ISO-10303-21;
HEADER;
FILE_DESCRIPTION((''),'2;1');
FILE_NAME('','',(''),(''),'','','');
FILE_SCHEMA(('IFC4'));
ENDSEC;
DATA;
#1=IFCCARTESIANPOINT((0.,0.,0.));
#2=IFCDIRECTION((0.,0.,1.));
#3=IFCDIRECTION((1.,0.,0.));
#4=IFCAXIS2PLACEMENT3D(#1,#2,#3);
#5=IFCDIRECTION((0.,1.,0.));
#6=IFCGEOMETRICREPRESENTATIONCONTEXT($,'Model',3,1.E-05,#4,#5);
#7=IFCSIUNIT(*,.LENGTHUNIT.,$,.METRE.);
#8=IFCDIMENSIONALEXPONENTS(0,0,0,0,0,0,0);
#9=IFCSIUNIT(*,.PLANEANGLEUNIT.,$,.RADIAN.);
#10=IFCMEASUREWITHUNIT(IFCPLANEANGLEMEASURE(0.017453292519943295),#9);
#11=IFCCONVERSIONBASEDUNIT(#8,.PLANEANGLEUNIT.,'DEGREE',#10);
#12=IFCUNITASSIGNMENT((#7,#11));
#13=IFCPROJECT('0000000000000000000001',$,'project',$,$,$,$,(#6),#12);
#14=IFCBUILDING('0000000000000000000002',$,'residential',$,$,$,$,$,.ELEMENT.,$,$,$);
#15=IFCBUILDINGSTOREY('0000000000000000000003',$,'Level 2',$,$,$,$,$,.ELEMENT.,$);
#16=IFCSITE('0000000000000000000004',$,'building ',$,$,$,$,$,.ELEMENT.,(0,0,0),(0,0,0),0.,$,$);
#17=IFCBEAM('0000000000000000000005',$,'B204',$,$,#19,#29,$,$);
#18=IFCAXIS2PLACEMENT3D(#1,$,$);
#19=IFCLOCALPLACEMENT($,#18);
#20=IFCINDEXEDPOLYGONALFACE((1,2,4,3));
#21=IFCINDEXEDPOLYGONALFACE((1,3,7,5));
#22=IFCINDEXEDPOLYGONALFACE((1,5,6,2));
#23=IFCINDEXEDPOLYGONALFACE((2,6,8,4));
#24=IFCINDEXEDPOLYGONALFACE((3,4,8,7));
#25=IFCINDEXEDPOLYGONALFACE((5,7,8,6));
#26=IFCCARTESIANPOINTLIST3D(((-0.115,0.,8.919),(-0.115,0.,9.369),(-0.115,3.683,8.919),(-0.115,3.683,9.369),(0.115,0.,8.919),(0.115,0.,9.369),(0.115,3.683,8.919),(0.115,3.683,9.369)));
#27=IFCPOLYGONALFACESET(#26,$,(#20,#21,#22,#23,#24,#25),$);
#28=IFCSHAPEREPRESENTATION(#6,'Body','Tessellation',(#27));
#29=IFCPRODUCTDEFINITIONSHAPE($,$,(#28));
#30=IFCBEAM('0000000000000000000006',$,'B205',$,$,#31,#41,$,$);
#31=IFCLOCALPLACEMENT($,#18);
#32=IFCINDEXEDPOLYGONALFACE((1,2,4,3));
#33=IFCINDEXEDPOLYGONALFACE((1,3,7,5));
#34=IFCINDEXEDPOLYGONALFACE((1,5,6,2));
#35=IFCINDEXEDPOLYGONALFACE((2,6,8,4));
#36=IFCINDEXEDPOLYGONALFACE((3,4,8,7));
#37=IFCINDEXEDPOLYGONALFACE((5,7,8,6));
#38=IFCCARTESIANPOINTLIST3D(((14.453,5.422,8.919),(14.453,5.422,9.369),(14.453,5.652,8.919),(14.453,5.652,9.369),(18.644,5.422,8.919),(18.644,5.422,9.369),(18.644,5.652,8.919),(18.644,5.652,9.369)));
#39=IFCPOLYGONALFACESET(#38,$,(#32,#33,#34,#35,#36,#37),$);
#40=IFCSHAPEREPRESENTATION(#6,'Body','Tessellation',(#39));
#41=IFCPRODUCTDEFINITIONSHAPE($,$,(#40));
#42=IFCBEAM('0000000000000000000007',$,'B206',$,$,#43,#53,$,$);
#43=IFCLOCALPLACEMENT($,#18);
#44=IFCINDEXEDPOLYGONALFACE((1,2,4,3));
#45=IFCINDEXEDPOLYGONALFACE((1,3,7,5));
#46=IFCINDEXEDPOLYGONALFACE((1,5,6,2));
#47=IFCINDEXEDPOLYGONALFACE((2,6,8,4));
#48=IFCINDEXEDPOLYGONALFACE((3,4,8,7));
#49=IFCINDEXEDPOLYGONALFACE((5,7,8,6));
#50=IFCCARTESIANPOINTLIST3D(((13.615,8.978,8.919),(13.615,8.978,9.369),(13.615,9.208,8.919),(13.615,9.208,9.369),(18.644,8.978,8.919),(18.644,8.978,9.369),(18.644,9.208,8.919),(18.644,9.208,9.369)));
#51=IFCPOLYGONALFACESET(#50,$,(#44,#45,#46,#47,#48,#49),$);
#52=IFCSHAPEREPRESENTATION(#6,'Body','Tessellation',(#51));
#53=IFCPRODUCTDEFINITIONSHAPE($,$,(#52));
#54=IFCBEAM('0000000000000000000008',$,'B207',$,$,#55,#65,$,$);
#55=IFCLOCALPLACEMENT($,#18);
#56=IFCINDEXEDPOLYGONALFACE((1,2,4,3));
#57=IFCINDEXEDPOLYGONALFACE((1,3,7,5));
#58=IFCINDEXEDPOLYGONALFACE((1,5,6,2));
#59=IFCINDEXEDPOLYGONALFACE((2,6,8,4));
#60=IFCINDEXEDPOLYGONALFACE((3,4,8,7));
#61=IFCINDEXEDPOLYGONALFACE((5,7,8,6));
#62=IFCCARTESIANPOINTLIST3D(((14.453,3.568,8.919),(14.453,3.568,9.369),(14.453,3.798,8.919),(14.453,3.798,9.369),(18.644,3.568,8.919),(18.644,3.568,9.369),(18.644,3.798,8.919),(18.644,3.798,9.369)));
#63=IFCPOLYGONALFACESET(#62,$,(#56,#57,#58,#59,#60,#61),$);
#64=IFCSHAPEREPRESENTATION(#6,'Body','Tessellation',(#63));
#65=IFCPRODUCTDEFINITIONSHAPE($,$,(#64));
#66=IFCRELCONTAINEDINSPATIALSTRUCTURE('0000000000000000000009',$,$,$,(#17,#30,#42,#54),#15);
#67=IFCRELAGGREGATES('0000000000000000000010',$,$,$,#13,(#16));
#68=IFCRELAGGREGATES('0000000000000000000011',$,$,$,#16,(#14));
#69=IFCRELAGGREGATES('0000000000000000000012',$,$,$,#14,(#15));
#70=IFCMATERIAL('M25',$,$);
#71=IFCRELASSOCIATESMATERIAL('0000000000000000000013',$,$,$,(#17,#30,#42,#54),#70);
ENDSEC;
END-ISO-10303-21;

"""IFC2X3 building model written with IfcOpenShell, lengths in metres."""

from ifc_helpers import new_model, entity, si_unit, converted_unit, direction, frame, frame_2d, origin_with_axes, place, context, project, spatial, rectangle, extrude, material, element, save


model = new_model("IFC2X3")

# Units and contexts
model_context = context("Model", 3, precision=1e-05, world=origin_with_axes(), true_north=direction((0.0, 1.0, 0.0)))
ifc_project = project(units=[si_unit("LENGTHUNIT", "METRE"), converted_unit("PLANEANGLEUNIT", "DEGREE", entity("IfcPlaneAngleMeasure", 0.017453292519943295), si_unit("PLANEANGLEUNIT", "RADIAN"), dimensions=[0, 0, 0, 0, 0, 0, 0])], contexts=[model_context])

# Site, building, storey
site = spatial("IfcSite", under=ifc_project, Name="building ", CompositionType="ELEMENT", RefLatitude=(0, 0, 0), RefLongitude=(0, 0, 0), RefElevation=0.0)
building = spatial("IfcBuilding", under=site, Name="residential", CompositionType="ELEMENT")
storey = spatial("IfcBuildingStorey", under=building, Name="Level 2", CompositionType="ELEMENT")

# Shared definitions
ifc_material = material(Name="M25")
placement = place(None, origin_with_axes())

# Beams
element("IfcBeam", 1, at=placement, inside=storey, material=ifc_material, Name="B204", context=model_context, shape_type="SweptSolid", body=[
    extrude(rectangle(XDim=0.23, YDim=0.45, at=frame_2d((0.0, 0.0), x_axis=(0.0, 1.0, 0.0))), frame((0.0, 0.0, 9.144), z_axis=(0.0, 1.0, 0.0), x_axis=(0.0, 0.0, -1.0)), (0.0, 0.0, 1.0), 3.683),
])
element("IfcBeam", 2, at=placement, inside=storey, material=ifc_material, Name="B205", context=model_context, shape_type="SweptSolid", body=[
    extrude(rectangle(XDim=0.23, YDim=0.45, at=frame_2d((0.0, 0.0), x_axis=(0.0, 1.0, 0.0))), frame((18.644, 5.537, 9.144), z_axis=(-1.0, 0.0, 0.0), x_axis=(0.0, 0.0, -1.0)), (0.0, 0.0, 1.0), 4.191),
])
element("IfcBeam", 3, at=placement, inside=storey, material=ifc_material, Name="B206", context=model_context, shape_type="SweptSolid", body=[
    extrude(rectangle(XDim=0.23, YDim=0.45, at=frame_2d((0.0, 0.0), x_axis=(0.0, 1.0, 0.0))), frame((18.644, 9.093, 9.144), z_axis=(-1.0, 0.0, 0.0), x_axis=(0.0, 0.0, -1.0)), (0.0, 0.0, 1.0), 5.029),
])
element("IfcBeam", 4, at=placement, inside=storey, material=ifc_material, Name="B207", context=model_context, shape_type="SweptSolid", body=[
    extrude(rectangle(XDim=0.23, YDim=0.45, at=frame_2d((0.0, 0.0), x_axis=(0.0, 1.0, 0.0))), frame((18.644, 3.683, 9.144), z_axis=(-1.0, 0.0, 0.0), x_axis=(0.0, 0.0, -1.0)), (0.0, 0.0, 1.0), 4.191),
])

save(model, "model.ifc")
